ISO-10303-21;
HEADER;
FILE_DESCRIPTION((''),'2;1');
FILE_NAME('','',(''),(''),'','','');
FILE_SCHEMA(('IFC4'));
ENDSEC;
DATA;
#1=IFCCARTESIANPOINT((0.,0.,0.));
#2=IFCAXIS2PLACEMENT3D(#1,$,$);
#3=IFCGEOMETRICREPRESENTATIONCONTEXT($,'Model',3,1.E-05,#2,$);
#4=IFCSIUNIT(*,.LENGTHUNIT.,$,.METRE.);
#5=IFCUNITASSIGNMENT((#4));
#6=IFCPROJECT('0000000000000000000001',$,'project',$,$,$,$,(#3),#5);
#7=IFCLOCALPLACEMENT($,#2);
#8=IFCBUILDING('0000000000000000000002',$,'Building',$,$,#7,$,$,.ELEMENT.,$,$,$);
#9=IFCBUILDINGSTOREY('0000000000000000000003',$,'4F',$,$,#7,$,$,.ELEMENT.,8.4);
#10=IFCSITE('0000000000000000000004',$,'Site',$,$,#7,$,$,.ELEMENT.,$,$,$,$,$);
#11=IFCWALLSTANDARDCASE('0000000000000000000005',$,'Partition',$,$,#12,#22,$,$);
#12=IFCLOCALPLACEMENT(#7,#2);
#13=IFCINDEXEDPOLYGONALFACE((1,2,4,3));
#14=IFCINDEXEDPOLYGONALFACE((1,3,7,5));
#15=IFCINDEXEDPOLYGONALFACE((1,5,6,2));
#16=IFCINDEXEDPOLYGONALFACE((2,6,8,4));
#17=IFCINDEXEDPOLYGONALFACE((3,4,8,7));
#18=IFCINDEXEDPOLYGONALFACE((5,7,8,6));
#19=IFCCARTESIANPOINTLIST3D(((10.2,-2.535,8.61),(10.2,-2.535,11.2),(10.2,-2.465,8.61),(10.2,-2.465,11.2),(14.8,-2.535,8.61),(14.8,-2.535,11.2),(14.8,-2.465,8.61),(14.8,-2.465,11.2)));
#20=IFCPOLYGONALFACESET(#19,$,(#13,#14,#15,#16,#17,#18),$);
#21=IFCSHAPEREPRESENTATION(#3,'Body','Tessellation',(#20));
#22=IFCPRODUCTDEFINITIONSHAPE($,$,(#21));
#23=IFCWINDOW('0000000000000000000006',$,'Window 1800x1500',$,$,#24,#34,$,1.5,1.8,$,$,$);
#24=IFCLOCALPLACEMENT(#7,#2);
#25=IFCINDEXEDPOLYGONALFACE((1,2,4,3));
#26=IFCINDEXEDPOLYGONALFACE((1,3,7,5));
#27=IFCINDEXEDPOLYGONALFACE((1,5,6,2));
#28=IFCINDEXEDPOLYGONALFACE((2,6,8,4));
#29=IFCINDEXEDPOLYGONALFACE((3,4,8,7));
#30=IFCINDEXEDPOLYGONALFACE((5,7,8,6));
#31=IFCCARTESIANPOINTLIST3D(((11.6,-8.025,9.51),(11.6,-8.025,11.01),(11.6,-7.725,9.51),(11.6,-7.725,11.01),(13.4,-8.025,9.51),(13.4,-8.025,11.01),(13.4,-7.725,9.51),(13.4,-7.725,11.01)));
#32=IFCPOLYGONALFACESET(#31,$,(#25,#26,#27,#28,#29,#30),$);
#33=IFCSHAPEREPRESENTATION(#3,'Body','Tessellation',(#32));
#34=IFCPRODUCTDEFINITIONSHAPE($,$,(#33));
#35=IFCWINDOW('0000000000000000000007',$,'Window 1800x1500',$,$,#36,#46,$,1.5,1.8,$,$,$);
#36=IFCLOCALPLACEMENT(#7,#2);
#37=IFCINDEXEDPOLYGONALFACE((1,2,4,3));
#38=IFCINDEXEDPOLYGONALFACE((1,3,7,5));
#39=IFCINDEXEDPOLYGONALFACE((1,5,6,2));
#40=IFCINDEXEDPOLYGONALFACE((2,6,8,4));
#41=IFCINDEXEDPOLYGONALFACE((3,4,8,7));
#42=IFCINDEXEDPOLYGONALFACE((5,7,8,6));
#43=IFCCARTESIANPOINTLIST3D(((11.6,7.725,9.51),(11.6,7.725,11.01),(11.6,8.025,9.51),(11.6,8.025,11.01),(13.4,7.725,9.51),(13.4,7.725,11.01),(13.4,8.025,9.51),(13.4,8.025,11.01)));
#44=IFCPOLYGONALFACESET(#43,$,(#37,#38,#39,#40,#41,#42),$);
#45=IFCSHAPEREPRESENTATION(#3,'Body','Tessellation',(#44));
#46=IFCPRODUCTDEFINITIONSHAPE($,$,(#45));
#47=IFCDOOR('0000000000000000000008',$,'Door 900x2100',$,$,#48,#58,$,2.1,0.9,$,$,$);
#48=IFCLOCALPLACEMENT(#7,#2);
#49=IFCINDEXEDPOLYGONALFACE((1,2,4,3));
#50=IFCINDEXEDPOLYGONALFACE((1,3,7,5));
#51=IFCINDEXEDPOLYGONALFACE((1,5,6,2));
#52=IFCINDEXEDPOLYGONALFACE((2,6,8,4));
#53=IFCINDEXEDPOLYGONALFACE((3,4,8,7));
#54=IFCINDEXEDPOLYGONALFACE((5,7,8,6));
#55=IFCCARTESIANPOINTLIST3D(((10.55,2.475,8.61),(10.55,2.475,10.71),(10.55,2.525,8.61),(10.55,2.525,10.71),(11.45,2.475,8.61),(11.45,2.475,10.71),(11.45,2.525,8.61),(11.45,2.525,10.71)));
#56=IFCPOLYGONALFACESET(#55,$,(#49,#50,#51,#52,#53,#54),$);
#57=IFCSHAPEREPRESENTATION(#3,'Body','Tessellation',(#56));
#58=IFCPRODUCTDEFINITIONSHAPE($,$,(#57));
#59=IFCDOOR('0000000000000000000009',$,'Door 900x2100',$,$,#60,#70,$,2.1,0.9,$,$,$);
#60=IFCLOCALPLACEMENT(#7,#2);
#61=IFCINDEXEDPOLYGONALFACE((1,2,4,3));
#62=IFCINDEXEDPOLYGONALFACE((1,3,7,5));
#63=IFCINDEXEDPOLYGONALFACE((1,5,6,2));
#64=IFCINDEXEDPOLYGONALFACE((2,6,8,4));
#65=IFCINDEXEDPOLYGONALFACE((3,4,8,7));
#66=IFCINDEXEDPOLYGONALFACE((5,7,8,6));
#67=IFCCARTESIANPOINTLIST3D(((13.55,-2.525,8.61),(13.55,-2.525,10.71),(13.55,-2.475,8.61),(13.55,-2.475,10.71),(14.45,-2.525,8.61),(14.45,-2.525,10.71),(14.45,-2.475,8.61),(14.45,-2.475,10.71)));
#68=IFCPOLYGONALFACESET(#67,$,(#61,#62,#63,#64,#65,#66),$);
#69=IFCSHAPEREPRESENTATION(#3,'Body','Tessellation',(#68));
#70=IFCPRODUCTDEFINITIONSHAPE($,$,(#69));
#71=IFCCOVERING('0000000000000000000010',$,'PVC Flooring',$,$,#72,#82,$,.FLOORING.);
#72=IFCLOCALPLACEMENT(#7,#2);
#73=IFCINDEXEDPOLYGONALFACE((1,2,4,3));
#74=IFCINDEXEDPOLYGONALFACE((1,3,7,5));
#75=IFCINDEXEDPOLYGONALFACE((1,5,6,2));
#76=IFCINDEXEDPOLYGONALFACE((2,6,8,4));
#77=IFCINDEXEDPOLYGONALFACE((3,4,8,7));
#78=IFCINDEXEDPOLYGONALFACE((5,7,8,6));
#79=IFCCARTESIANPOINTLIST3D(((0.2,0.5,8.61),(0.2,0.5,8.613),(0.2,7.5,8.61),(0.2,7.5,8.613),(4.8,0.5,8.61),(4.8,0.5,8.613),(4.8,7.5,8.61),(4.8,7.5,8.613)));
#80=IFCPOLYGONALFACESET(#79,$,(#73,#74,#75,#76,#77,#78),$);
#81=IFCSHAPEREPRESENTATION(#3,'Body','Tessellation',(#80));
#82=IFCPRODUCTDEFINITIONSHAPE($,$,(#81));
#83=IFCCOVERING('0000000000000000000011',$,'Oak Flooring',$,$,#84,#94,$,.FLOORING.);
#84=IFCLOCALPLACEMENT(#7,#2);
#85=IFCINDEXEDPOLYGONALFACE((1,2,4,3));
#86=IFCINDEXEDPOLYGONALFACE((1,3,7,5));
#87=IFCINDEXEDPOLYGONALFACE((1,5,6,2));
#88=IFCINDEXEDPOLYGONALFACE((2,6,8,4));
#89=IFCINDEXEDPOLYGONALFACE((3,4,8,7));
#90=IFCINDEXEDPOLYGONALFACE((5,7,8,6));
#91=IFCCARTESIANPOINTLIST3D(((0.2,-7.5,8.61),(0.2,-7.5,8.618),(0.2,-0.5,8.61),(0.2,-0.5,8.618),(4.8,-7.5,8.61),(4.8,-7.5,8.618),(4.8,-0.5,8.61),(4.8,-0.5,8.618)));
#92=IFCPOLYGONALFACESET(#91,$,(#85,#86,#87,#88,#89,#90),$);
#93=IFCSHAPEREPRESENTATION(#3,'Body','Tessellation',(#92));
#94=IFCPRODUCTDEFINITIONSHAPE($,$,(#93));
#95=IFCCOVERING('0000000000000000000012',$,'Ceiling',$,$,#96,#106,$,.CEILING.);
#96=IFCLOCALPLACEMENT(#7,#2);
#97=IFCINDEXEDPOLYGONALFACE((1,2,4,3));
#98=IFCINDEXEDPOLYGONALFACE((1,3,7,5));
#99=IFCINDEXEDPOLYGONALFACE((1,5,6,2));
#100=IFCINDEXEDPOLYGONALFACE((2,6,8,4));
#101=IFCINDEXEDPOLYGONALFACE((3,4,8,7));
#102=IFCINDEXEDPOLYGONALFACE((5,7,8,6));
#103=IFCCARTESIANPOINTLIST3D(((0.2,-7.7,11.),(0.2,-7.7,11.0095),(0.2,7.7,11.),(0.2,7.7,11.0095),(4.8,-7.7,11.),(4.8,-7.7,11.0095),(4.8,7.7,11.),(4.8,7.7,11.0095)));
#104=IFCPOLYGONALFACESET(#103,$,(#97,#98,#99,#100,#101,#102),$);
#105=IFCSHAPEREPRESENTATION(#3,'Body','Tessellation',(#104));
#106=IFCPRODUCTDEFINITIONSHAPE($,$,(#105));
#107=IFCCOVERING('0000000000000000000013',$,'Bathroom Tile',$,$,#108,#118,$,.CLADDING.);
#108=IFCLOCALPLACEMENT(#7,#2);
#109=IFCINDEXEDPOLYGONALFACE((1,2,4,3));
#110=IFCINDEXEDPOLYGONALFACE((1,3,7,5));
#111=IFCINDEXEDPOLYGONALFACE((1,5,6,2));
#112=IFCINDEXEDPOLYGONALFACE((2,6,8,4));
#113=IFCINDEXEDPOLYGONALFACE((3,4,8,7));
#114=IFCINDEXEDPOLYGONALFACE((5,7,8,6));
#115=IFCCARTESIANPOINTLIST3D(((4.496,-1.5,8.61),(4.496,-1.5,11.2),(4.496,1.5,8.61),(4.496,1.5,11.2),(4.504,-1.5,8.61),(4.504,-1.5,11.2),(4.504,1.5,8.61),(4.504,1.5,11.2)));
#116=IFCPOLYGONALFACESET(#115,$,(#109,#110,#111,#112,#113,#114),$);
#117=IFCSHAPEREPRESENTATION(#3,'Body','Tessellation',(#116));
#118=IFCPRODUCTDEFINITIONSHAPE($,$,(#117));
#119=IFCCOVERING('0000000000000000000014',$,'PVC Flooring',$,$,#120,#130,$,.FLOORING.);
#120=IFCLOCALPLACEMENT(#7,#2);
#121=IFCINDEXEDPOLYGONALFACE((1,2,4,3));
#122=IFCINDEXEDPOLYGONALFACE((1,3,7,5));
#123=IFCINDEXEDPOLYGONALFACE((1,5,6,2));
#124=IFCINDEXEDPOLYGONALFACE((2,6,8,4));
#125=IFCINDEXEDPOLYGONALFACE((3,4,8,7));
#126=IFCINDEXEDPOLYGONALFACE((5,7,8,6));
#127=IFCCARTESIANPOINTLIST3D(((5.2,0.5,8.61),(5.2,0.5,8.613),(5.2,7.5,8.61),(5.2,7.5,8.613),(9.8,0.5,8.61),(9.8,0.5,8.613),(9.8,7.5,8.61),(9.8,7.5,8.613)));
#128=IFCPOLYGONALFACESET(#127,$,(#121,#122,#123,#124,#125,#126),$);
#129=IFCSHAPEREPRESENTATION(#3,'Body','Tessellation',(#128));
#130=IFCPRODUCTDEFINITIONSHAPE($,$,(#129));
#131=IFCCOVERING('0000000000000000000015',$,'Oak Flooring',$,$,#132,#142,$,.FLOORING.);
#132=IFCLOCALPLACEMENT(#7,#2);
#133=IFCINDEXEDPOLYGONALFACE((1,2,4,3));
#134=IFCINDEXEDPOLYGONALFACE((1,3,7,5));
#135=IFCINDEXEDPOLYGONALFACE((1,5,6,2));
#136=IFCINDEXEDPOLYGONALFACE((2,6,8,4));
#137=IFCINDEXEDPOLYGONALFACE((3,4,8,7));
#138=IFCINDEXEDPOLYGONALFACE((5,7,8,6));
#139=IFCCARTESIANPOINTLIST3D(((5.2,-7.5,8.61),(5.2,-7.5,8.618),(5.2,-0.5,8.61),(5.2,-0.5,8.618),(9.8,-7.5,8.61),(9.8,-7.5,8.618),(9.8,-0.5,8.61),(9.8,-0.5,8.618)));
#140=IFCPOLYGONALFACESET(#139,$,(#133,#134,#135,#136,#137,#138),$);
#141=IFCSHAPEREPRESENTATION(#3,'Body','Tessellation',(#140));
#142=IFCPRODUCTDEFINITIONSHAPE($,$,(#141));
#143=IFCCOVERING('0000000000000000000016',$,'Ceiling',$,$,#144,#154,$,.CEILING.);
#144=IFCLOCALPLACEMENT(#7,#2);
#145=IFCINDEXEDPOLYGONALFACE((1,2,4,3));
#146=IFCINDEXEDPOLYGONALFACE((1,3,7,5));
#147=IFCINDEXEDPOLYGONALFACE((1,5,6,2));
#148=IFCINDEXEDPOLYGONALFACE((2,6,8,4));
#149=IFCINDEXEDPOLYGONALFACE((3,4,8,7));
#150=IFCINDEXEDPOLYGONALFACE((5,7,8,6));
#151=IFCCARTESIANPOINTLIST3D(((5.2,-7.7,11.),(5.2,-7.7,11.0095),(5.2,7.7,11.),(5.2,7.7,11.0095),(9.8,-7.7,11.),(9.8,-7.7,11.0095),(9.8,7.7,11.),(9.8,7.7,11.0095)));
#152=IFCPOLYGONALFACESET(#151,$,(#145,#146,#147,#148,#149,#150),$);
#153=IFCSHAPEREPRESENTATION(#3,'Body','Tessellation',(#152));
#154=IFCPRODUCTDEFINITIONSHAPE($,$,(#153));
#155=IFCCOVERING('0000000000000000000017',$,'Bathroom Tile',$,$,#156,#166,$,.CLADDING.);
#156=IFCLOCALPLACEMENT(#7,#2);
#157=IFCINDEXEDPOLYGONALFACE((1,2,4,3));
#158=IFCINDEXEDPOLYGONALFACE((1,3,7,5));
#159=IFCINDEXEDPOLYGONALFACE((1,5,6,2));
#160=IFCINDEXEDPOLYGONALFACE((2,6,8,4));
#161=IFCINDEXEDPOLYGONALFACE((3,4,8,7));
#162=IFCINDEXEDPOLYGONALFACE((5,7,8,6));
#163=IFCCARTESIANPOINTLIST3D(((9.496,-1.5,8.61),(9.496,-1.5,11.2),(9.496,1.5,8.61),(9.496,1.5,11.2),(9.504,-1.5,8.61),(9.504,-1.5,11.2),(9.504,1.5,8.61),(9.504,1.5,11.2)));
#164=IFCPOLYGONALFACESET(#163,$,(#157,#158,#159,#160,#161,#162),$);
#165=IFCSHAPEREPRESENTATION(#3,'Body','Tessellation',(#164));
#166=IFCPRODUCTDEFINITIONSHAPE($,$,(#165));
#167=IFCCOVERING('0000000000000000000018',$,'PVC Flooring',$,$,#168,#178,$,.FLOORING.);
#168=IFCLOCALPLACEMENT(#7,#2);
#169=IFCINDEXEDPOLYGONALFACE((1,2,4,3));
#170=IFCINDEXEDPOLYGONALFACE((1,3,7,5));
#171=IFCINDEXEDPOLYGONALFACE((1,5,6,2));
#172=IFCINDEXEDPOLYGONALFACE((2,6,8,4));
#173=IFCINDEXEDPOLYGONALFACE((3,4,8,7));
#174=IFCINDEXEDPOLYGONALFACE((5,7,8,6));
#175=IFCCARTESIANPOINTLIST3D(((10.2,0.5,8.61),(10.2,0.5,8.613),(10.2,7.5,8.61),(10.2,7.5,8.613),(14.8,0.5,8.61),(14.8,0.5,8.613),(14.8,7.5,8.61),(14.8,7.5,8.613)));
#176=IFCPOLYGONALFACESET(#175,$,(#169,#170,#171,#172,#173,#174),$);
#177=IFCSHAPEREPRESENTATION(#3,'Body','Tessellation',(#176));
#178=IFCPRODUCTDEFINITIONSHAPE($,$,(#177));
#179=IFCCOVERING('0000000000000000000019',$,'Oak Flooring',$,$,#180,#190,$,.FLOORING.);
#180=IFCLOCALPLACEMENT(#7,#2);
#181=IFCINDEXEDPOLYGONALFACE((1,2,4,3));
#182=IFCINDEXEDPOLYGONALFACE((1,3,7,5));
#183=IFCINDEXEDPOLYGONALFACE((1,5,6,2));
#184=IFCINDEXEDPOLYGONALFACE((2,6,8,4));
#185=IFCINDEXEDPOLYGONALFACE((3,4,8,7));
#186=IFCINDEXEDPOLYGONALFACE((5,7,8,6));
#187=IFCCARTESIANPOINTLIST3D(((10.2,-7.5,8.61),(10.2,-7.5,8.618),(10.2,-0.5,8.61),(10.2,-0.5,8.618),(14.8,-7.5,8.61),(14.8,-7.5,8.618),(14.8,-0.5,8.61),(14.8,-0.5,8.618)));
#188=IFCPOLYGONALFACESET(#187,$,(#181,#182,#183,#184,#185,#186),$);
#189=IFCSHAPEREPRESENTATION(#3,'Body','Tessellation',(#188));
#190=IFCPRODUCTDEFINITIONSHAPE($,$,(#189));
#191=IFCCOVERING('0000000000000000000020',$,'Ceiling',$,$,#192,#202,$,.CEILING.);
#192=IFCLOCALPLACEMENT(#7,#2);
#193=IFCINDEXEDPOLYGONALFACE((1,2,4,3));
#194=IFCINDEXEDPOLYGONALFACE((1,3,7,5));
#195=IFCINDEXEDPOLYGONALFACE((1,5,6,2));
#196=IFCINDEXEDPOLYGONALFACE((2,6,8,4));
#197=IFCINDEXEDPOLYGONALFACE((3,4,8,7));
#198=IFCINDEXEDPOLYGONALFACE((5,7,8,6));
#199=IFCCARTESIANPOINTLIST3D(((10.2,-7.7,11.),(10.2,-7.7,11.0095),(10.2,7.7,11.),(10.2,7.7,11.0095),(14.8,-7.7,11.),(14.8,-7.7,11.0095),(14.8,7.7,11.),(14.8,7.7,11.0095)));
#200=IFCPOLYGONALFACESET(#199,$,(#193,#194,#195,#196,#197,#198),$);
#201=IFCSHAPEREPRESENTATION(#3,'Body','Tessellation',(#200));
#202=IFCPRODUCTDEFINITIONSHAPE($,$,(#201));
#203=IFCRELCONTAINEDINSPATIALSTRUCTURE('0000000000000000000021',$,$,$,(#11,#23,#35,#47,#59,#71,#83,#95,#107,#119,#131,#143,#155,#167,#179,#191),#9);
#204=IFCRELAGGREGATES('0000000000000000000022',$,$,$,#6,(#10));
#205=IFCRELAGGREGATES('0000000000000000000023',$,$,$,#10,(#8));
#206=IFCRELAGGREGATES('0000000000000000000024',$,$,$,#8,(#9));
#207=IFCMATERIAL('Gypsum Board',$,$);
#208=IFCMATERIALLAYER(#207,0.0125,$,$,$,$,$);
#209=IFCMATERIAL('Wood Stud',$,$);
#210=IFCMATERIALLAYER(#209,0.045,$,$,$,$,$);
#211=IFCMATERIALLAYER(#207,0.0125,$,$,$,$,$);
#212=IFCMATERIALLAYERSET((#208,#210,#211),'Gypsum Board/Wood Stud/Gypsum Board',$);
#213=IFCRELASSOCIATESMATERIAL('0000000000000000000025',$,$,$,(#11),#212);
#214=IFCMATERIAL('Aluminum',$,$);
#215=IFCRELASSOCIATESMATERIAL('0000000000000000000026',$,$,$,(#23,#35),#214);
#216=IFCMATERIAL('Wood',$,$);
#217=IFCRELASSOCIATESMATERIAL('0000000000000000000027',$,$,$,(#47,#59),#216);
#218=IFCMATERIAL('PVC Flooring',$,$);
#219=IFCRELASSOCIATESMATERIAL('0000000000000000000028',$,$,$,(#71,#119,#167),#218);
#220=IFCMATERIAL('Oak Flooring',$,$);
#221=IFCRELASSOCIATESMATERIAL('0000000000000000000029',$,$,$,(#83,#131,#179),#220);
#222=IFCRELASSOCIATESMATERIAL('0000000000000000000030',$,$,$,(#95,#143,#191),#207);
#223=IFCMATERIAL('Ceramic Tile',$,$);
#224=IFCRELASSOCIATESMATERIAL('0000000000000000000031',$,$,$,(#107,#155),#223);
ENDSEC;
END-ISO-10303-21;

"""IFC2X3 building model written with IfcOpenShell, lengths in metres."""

from ifc_helpers import new_model, si_unit, frame, origin, origin_2d, place, context, project, spatial, rectangle, extrude, material, layer, layer_set, layer_usage, element, save


model = new_model("IFC2X3")

# Units and contexts
model_context = context("Model", 3, precision=1e-05, world=origin())
ifc_project = project(units=[si_unit("LENGTHUNIT", "METRE")], contexts=[model_context])

# Site, building, storey
placement = place(None, origin())
site = spatial("IfcSite", under=ifc_project, at=placement, Name="Site", CompositionType="ELEMENT")
building = spatial("IfcBuilding", under=site, at=placement, Name="Building", CompositionType="ELEMENT")
storey = spatial("IfcBuildingStorey", under=building, at=placement, Name="4F", CompositionType="ELEMENT", Elevation=8.4)

# Shared definitions
ifc_material_1 = material(Name="Gypsum Board")
ifc_layer_1 = layer(ifc_material_1, 0.0125)
ifc_material_2 = material(Name="Wood Stud")
ifc_layer_2 = layer(ifc_material_2, 0.045)
ifc_layer_3 = layer(ifc_material_1, 0.0125)
ifc_layer_set_1 = layer_set([ifc_layer_1, ifc_layer_2, ifc_layer_3], Name="Gypsum Board/Wood Stud/Gypsum Board")
ifc_layer_usage_1 = layer_usage(ifc_layer_set_1, "AXIS2", "POSITIVE", 0.0)

# Shared definitions
ifc_material_3 = material(Name="Aluminum")

# Shared definitions
ifc_material_4 = material(Name="Wood")

# Wall
for number, where, name in (
    (1, (12.5, -2.5, 8.61), "Partition"),
):
    element("IfcWallStandardCase", number, at=place(None, frame(where)), inside=storey, material=ifc_layer_usage_1, Name=name, context=model_context, shape_type="SweptSolid", body=[
        extrude(rectangle(XDim=4.6, YDim=0.07, at=origin_2d()), origin(), (0.0, 0.0, 1.0), 2.59),
    ])

# Windows
for number, where, name in (
    (2, (12.5, -7.875, 9.51), "Window 1800x1500"),
    (3, (12.5, 7.875, 9.51), "Window 1800x1500"),
):
    element("IfcWindow", number, at=place(None, frame(where)), inside=storey, material=ifc_material_3, Name=name, OverallHeight=1.5, OverallWidth=1.8, context=model_context, shape_type="SweptSolid", body=[
        extrude(rectangle(XDim=1.8, YDim=0.3, at=origin_2d()), origin(), (0.0, 0.0, 1.0), 1.5),
    ])

# Doors
for number, where, name in (
    (4, (11.0, 2.5, 8.61), "Door 900x2100"),
    (5, (14.0, -2.5, 8.61), "Door 900x2100"),
):
    element("IfcDoor", number, at=place(None, frame(where)), inside=storey, material=ifc_material_4, Name=name, OverallHeight=2.1, OverallWidth=0.9, context=model_context, shape_type="SweptSolid", body=[
        extrude(rectangle(XDim=0.9, YDim=0.05, at=origin_2d()), origin(), (0.0, 0.0, 1.0), 2.1),
    ])

# Coverings
ifc_material_5 = material(Name="PVC Flooring")
covering_1_placement = place(None, frame((2.5, 4.0, 8.61)))
element("IfcCovering", 6, at=covering_1_placement, inside=storey, material=ifc_material_5, Name="PVC Flooring", PredefinedType="FLOORING", context=model_context, shape_type="SweptSolid", body=[
    extrude(rectangle(XDim=4.6, YDim=7.0, at=origin_2d()), origin(), (0.0, 0.0, 1.0), 0.003),
])
ifc_material_6 = material(Name="Oak Flooring")
covering_2_placement = place(None, frame((2.5, -4.0, 8.61)))
element("IfcCovering", 7, at=covering_2_placement, inside=storey, material=ifc_material_6, Name="Oak Flooring", PredefinedType="FLOORING", context=model_context, shape_type="SweptSolid", body=[
    extrude(rectangle(XDim=4.6, YDim=7.0, at=origin_2d()), origin(), (0.0, 0.0, 1.0), 0.008),
])
covering_3_placement = place(None, frame((2.5, 0.0, 11.0)))
element("IfcCovering", 8, at=covering_3_placement, inside=storey, material=ifc_material_1, Name="Ceiling", PredefinedType="CEILING", context=model_context, shape_type="SweptSolid", body=[
    extrude(rectangle(XDim=4.6, YDim=15.4, at=origin_2d()), origin(), (0.0, 0.0, 1.0), 0.0095),
])
ifc_material_7 = material(Name="Ceramic Tile")
covering_4_placement = place(None, frame((4.5, 0.0, 8.61)))
element("IfcCovering", 9, at=covering_4_placement, inside=storey, material=ifc_material_7, Name="Bathroom Tile", PredefinedType="CLADDING", context=model_context, shape_type="SweptSolid", body=[
    extrude(rectangle(XDim=0.008, YDim=3.0, at=origin_2d()), origin(), (0.0, 0.0, 1.0), 2.59),
])
covering_5_placement = place(None, frame((7.5, 4.0, 8.61)))
element("IfcCovering", 10, at=covering_5_placement, inside=storey, material=ifc_material_5, Name="PVC Flooring", PredefinedType="FLOORING", context=model_context, shape_type="SweptSolid", body=[
    extrude(rectangle(XDim=4.6, YDim=7.0, at=origin_2d()), origin(), (0.0, 0.0, 1.0), 0.003),
])
covering_6_placement = place(None, frame((7.5, -4.0, 8.61)))
element("IfcCovering", 11, at=covering_6_placement, inside=storey, material=ifc_material_6, Name="Oak Flooring", PredefinedType="FLOORING", context=model_context, shape_type="SweptSolid", body=[
    extrude(rectangle(XDim=4.6, YDim=7.0, at=origin_2d()), origin(), (0.0, 0.0, 1.0), 0.008),
])
covering_7_placement = place(None, frame((7.5, 0.0, 11.0)))
element("IfcCovering", 12, at=covering_7_placement, inside=storey, material=ifc_material_1, Name="Ceiling", PredefinedType="CEILING", context=model_context, shape_type="SweptSolid", body=[
    extrude(rectangle(XDim=4.6, YDim=15.4, at=origin_2d()), origin(), (0.0, 0.0, 1.0), 0.0095),
])
covering_8_placement = place(None, frame((9.5, 0.0, 8.61)))
element("IfcCovering", 13, at=covering_8_placement, inside=storey, material=ifc_material_7, Name="Bathroom Tile", PredefinedType="CLADDING", context=model_context, shape_type="SweptSolid", body=[
    extrude(rectangle(XDim=0.008, YDim=3.0, at=origin_2d()), origin(), (0.0, 0.0, 1.0), 2.59),
])
covering_9_placement = place(None, frame((12.5, 4.0, 8.61)))
element("IfcCovering", 14, at=covering_9_placement, inside=storey, material=ifc_material_5, Name="PVC Flooring", PredefinedType="FLOORING", context=model_context, shape_type="SweptSolid", body=[
    extrude(rectangle(XDim=4.6, YDim=7.0, at=origin_2d()), origin(), (0.0, 0.0, 1.0), 0.003),
])
covering_10_placement = place(None, frame((12.5, -4.0, 8.61)))
element("IfcCovering", 15, at=covering_10_placement, inside=storey, material=ifc_material_6, Name="Oak Flooring", PredefinedType="FLOORING", context=model_context, shape_type="SweptSolid", body=[
    extrude(rectangle(XDim=4.6, YDim=7.0, at=origin_2d()), origin(), (0.0, 0.0, 1.0), 0.008),
])
covering_11_placement = place(None, frame((12.5, 0.0, 11.0)))
element("IfcCovering", 16, at=covering_11_placement, inside=storey, material=ifc_material_1, Name="Ceiling", PredefinedType="CEILING", context=model_context, shape_type="SweptSolid", body=[
    extrude(rectangle(XDim=4.6, YDim=15.4, at=origin_2d()), origin(), (0.0, 0.0, 1.0), 0.0095),
])

save(model, "model.ifc")
